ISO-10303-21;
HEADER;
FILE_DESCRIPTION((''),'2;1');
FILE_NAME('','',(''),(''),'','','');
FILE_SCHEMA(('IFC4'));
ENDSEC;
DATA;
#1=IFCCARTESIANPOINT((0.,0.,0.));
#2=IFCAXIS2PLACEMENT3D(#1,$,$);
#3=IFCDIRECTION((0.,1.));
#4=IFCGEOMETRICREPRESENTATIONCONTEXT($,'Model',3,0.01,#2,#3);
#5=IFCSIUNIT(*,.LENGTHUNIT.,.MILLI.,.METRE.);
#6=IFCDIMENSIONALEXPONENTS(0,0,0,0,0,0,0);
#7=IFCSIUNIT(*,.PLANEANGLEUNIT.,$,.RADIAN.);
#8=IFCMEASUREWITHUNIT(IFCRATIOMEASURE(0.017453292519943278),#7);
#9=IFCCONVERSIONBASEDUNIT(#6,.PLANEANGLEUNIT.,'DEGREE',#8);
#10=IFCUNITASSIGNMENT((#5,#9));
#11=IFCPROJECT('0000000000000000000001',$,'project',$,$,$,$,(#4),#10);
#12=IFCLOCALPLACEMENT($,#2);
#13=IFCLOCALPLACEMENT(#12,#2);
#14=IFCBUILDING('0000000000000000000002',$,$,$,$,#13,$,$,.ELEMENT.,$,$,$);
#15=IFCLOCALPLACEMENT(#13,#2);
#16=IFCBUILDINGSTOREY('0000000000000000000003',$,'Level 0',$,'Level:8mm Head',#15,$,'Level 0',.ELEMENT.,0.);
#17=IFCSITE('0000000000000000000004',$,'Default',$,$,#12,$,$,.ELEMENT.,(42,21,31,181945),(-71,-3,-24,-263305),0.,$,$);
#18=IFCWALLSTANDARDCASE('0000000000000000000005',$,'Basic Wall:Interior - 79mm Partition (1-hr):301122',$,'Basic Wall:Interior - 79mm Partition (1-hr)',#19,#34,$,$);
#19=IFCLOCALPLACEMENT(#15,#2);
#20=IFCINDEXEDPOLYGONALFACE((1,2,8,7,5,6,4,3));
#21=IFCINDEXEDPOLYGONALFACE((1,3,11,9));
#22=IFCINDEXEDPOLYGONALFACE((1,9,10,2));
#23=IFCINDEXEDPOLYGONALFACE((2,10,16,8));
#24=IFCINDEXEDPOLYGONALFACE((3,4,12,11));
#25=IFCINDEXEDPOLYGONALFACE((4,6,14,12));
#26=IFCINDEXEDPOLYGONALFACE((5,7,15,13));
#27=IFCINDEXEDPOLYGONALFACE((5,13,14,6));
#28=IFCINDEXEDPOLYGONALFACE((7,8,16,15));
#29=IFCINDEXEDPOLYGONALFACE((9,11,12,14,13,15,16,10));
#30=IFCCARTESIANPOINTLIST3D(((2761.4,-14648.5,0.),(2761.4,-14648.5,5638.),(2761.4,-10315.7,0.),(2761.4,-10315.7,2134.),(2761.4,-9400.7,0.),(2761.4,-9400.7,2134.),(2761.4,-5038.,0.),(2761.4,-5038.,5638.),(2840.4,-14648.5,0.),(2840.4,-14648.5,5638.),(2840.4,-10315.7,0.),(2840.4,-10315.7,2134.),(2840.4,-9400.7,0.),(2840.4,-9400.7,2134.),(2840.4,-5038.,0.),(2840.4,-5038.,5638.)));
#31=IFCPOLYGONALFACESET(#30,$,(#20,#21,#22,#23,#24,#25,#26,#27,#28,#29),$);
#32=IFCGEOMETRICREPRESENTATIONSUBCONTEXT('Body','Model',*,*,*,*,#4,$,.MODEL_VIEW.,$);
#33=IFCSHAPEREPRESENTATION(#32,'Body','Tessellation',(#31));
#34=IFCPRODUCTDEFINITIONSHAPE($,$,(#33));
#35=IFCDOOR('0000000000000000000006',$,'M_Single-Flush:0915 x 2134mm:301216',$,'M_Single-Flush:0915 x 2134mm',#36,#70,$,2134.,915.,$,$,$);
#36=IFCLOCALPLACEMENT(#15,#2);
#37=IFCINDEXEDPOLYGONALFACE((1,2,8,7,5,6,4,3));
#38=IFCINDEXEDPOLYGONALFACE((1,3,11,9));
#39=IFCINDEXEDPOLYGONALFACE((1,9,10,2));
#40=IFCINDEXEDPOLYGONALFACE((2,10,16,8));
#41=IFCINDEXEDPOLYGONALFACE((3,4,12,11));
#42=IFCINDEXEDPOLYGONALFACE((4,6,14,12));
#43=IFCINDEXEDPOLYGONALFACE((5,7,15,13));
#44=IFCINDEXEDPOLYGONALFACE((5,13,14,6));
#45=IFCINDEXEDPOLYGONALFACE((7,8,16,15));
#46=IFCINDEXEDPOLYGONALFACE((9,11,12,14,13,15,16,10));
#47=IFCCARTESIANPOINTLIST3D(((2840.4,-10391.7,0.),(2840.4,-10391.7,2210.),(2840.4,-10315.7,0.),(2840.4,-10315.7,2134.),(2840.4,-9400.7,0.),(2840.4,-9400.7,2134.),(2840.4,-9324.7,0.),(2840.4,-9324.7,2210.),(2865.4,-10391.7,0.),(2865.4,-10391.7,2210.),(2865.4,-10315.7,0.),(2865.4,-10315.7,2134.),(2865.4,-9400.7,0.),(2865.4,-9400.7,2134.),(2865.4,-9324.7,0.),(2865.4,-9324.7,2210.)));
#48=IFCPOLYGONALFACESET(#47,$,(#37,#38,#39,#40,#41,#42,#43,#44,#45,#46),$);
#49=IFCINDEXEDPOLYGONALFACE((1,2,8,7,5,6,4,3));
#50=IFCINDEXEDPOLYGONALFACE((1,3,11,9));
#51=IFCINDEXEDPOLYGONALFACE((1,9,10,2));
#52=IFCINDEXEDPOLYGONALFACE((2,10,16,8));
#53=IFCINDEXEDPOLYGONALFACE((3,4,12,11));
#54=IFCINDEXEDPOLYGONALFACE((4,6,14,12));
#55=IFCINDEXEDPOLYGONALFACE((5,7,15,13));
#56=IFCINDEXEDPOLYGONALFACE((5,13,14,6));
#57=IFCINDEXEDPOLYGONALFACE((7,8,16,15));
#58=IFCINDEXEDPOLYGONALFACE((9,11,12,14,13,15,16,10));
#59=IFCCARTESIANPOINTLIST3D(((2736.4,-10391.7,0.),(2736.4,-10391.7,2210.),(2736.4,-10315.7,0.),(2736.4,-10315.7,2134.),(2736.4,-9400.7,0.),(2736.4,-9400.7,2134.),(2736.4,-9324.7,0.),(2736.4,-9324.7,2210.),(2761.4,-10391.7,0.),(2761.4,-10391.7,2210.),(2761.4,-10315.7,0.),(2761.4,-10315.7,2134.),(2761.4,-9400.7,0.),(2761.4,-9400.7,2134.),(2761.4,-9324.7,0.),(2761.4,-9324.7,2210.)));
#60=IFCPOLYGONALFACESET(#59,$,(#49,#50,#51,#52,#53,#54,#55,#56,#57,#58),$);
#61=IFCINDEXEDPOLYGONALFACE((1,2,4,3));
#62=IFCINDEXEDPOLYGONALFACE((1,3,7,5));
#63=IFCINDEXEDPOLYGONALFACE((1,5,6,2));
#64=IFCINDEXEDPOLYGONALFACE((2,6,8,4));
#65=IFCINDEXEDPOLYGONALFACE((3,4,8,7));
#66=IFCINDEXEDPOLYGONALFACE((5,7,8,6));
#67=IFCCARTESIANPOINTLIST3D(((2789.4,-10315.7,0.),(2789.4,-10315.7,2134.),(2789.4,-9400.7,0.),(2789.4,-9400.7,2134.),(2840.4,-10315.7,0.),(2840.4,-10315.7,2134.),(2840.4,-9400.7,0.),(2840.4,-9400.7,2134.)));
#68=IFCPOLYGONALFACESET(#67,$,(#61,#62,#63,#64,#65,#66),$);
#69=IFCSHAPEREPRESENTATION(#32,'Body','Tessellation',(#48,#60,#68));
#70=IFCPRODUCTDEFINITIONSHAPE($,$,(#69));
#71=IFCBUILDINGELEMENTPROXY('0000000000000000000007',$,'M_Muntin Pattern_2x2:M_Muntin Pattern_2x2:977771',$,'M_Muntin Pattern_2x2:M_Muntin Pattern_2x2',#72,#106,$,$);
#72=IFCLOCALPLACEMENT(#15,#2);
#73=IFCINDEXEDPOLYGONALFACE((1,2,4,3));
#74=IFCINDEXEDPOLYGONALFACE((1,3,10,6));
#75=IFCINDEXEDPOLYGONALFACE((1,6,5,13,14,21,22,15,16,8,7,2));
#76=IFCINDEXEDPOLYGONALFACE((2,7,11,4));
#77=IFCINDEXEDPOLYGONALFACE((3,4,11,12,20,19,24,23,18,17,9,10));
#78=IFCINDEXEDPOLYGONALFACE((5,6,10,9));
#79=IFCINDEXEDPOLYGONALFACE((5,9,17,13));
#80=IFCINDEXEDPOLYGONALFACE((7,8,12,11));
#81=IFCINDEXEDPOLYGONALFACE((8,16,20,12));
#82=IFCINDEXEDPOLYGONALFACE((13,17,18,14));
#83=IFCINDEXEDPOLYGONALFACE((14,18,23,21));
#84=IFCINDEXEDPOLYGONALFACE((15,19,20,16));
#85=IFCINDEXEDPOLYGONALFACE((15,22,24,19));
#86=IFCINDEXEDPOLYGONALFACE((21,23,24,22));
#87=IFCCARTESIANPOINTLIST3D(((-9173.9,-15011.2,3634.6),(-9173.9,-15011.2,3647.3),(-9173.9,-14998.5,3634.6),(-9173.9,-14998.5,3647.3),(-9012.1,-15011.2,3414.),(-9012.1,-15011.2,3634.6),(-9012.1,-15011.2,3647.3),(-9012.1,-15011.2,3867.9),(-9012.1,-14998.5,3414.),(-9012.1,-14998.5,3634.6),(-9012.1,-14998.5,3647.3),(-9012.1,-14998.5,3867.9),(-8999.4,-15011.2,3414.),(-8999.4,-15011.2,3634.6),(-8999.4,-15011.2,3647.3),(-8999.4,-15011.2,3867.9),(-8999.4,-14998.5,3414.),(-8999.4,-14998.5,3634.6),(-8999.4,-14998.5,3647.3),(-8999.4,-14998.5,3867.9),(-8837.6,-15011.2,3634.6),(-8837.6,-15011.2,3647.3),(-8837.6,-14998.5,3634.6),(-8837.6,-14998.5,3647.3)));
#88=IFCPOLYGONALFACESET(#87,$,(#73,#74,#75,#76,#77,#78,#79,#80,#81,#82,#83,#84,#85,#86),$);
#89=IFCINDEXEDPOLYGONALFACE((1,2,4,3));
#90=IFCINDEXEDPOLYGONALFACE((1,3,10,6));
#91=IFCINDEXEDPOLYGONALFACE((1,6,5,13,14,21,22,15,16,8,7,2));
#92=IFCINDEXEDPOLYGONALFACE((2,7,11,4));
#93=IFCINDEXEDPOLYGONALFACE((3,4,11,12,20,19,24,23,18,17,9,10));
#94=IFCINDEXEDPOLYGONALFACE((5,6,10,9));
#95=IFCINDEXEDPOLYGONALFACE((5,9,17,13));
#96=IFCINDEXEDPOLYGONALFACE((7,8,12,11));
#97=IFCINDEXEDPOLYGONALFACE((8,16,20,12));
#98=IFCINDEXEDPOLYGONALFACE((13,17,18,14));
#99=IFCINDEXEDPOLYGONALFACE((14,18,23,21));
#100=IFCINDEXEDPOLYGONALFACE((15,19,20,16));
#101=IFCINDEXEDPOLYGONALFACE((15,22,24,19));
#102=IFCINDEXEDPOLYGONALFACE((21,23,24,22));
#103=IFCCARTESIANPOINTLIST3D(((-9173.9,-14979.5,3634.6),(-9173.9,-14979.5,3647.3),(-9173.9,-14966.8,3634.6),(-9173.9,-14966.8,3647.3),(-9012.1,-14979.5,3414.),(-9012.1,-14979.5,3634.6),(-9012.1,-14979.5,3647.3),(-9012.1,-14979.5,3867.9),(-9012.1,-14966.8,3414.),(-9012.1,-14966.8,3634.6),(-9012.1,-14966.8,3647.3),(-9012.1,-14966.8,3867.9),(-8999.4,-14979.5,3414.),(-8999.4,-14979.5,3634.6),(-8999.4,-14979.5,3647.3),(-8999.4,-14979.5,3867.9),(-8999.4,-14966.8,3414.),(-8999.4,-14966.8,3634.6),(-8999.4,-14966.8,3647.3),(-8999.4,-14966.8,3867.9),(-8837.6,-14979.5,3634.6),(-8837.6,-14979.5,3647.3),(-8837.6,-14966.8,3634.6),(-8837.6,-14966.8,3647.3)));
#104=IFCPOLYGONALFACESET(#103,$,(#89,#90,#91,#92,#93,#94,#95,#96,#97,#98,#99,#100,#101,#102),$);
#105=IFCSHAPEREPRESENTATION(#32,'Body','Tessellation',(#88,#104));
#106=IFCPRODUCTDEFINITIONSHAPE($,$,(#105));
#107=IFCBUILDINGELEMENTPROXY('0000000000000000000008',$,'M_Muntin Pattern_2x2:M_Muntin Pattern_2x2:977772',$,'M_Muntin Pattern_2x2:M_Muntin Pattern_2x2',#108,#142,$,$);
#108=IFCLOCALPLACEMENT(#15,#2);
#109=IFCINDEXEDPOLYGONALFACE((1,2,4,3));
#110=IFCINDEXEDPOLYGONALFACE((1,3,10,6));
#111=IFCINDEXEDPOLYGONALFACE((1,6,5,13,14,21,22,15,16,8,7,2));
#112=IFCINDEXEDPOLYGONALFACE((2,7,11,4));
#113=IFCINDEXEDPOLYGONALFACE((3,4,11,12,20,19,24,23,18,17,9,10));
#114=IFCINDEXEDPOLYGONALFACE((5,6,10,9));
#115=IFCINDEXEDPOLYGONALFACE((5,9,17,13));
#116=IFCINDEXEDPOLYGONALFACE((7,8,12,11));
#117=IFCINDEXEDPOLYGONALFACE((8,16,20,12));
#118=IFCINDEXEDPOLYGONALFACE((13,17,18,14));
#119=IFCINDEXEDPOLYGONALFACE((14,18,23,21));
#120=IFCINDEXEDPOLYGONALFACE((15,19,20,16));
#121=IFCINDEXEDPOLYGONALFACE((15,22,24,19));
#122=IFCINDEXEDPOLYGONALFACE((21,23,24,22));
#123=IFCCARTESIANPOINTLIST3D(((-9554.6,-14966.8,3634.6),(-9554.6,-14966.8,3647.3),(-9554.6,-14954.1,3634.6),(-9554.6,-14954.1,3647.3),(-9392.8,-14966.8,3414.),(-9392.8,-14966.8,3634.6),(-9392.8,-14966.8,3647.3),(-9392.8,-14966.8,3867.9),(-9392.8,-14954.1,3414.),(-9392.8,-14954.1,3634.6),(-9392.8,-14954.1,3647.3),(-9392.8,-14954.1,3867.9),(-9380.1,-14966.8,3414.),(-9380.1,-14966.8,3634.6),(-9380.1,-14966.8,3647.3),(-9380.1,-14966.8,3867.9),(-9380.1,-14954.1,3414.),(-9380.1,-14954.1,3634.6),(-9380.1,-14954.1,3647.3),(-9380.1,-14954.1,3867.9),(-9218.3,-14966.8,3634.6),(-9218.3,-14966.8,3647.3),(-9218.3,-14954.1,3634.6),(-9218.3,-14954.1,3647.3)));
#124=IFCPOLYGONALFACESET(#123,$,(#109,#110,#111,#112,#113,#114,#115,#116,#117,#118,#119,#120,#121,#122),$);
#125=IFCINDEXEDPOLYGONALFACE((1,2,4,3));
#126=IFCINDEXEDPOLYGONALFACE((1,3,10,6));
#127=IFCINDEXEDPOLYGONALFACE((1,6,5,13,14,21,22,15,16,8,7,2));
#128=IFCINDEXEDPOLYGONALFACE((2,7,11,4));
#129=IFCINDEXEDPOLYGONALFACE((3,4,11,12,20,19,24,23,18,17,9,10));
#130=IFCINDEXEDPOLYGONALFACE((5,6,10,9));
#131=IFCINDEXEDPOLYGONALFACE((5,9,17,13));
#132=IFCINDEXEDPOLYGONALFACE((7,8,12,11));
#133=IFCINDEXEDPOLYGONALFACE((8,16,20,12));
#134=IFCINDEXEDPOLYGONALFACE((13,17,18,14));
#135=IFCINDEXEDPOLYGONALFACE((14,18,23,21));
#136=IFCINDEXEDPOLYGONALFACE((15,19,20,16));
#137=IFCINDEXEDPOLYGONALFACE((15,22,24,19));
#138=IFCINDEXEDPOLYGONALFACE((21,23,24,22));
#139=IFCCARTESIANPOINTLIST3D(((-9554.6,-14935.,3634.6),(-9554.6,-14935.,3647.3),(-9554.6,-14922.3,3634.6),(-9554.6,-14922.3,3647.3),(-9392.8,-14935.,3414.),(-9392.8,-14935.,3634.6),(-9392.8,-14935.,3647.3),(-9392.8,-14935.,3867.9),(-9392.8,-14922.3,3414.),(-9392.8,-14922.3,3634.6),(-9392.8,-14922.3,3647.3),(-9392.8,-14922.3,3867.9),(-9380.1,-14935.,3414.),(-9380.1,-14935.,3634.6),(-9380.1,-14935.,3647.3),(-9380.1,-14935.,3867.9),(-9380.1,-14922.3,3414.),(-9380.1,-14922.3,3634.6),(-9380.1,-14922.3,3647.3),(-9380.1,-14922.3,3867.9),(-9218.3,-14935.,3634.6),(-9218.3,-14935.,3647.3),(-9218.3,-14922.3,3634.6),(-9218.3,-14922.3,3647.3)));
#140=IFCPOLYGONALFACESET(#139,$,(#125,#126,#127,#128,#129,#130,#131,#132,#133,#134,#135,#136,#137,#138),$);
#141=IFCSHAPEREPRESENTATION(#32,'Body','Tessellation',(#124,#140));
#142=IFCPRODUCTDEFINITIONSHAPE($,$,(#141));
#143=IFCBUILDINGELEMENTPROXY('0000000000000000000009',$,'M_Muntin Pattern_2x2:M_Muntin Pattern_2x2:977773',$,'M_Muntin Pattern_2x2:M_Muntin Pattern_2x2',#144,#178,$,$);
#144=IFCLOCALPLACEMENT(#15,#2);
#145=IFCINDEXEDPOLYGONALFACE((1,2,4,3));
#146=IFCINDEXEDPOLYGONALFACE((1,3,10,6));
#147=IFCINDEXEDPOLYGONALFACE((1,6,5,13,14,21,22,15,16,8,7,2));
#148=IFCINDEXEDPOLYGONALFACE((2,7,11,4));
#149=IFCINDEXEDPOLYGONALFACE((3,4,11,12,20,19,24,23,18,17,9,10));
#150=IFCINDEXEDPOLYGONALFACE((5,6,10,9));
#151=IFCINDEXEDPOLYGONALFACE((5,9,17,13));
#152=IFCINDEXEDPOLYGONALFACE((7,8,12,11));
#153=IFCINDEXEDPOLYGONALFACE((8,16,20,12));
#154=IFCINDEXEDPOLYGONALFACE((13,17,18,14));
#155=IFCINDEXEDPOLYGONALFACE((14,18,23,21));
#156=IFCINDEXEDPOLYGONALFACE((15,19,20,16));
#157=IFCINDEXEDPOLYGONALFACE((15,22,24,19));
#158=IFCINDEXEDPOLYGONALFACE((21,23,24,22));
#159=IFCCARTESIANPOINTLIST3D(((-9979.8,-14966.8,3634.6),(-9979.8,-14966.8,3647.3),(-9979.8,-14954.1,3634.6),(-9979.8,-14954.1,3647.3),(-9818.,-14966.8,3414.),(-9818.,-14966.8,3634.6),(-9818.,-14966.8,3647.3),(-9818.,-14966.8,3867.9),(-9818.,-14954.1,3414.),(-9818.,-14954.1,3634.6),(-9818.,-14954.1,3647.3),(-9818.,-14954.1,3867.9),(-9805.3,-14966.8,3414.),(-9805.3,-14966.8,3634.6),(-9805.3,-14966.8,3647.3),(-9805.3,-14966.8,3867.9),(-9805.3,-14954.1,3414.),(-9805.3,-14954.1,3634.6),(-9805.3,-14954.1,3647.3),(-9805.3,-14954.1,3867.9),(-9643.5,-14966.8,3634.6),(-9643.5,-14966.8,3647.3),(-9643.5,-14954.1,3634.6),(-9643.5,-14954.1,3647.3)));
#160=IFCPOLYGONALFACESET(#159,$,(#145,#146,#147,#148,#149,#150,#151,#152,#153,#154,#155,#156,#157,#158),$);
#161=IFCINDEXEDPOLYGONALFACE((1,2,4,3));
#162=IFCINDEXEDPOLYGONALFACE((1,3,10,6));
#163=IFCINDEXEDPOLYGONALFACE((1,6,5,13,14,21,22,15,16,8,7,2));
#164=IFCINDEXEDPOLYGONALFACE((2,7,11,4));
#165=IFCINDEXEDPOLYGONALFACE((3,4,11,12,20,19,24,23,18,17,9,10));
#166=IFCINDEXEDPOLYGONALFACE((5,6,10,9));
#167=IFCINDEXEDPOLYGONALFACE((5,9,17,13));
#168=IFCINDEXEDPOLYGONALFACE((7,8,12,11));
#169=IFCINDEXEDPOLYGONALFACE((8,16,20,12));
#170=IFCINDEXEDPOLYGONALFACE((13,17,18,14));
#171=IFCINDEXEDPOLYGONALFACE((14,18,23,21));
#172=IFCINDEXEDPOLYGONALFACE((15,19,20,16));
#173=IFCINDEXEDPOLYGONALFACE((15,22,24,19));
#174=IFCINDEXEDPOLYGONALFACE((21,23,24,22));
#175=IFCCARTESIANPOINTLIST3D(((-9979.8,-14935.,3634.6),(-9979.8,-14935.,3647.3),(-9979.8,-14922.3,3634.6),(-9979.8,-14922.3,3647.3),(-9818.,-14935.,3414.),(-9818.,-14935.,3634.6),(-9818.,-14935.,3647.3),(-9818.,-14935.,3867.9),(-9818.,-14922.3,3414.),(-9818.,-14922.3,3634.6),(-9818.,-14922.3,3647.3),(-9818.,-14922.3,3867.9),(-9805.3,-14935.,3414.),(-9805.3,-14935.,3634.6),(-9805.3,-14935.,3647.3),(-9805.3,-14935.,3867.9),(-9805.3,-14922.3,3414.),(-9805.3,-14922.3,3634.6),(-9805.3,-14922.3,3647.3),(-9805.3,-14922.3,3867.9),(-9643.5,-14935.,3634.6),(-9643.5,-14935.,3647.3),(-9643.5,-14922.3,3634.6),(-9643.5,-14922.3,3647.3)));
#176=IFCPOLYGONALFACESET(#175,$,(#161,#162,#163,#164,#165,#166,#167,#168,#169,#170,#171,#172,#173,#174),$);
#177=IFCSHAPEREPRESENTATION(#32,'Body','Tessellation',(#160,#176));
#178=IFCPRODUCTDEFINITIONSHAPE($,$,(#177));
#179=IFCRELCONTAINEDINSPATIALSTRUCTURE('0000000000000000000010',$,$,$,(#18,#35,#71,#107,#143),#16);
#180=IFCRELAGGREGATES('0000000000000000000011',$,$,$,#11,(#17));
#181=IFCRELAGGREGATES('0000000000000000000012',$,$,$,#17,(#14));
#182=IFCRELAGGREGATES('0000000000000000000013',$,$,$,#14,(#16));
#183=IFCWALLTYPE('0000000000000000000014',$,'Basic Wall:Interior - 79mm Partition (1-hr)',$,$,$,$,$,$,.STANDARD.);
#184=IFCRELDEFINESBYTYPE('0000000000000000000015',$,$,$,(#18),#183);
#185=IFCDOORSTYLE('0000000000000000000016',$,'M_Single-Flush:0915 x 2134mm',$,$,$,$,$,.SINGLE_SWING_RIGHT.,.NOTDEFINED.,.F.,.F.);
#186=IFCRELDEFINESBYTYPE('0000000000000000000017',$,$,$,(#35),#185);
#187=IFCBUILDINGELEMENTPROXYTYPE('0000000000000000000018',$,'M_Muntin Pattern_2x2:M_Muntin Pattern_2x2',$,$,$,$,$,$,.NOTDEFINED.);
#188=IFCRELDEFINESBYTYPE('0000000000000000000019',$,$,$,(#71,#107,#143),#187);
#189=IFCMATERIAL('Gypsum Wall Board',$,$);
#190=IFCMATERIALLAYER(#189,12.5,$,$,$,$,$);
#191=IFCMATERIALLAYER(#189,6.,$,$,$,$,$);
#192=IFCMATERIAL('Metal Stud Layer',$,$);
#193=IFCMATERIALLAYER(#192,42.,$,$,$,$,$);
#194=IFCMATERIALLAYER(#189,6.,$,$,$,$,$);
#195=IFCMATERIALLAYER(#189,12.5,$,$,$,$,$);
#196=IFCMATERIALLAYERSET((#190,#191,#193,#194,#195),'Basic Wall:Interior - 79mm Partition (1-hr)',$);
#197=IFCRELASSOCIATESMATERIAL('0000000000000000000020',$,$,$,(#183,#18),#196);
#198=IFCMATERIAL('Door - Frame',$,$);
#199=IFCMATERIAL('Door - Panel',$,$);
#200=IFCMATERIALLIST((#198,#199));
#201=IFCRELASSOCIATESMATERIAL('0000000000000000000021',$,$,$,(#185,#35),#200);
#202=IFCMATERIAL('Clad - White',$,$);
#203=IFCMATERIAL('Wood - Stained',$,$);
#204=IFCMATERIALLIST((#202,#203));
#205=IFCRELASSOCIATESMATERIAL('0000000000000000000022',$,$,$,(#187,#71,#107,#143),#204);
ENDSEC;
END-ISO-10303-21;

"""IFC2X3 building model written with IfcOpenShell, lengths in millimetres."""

from ifc_helpers import new_model, entity, si_unit, converted_unit, direction, frame, frame_2d, origin, origin_2d_with_axis, place, context, subcontext, project, spatial, polyline, rectangle, outline, extrude, clip, bounded_halfspace, source, transform, mapped, material, material_list, layer, layer_set, layer_usage, type_object, type_shapes, element, fill, save


model = new_model("IFC2X3")

# Units and contexts
model_context = context("Model", 3, precision=0.01, world=origin(), true_north=direction((0.0, 1.0)))
body_context = subcontext(model_context, "Body", "Model", "MODEL_VIEW")
ifc_project = project(units=[si_unit("LENGTHUNIT", "METRE", prefix="MILLI"), converted_unit("PLANEANGLEUNIT", "DEGREE", entity("IfcRatioMeasure", 0.017453292519943278), si_unit("PLANEANGLEUNIT", "RADIAN"), dimensions=[0, 0, 0, 0, 0, 0, 0])], contexts=[model_context])

# Site, building, storey
site_placement = place(None, origin())
site = spatial("IfcSite", under=ifc_project, at=site_placement, Name="Default", CompositionType="ELEMENT", RefLatitude=(42, 21, 31, 181945), RefLongitude=(-71, -3, -24, -263305), RefElevation=0.0)
building_placement = place(site_placement, origin())
building = spatial("IfcBuilding", under=site, at=building_placement, CompositionType="ELEMENT")
storey_placement = place(building_placement, origin())
storey = spatial("IfcBuildingStorey", under=building, at=storey_placement, Name="Level 0", ObjectType="Level:8mm Head", LongName="Level 0", CompositionType="ELEMENT", Elevation=0.0)

# Shared definitions
ifc_material_1 = material(Name="Metal Stud Layer")
ifc_material_2 = material(Name="Gypsum Wall Board")
ifc_material_3 = material(Name="Door - Frame")
ifc_material_4 = material(Name="Door - Panel")
ifc_material_list_1 = material_list([ifc_material_3, ifc_material_4])

# Wall, opening, door
ifc_layer_1 = layer(ifc_material_2, 12.5)
ifc_layer_2 = layer(ifc_material_2, 6.0)
ifc_layer_3 = layer(ifc_material_1, 42.0)
ifc_layer_4 = layer(ifc_material_2, 6.0)
ifc_layer_5 = layer(ifc_material_2, 12.5)
ifc_layer_set_1 = layer_set([ifc_layer_1, ifc_layer_2, ifc_layer_3, ifc_layer_4, ifc_layer_5], Name="Basic Wall:Interior - 79mm Partition (1-hr)")
ifc_layer_usage_1 = layer_usage(ifc_layer_set_1, "AXIS2", "NEGATIVE", 39.5)
wall_type_1 = type_object("IfcWallType", Name="Basic Wall:Interior - 79mm Partition (1-hr)", PredefinedType="STANDARD", material=ifc_layer_set_1)
door_style_1 = type_object("IfcDoorStyle", Name="M_Single-Flush:0915 x 2134mm", ConstructionType="NOTDEFINED", OperationType="SINGLE_SWING_RIGHT", ParameterTakesPrecedence=False, Sizeable=False, material=ifc_material_list_1)
shared_shape_1 = source(origin(), body_context, "Body", "SweptSolid", [
    extrude(outline(polyline([(-533.5, -1124.0), (533.5, -1124.0), (533.5, 1086.0), (457.5, 1086.0), (457.5, -1048.0), (-457.5, -1048.0), (-457.5, 1086.0), (-533.5, 1086.0), (-533.5, -1124.0)])), frame((457.5, 79.0, 1086.0), z_axis=(0.0, 1.0, 0.0), x_axis=(1.0, 0.0, 0.0)), (0.0, 0.0, 1.0), 25.0),
    extrude(outline(polyline([(-1124.0, -533.5), (1086.0, -533.5), (1086.0, -457.5), (-1048.0, -457.5), (-1048.0, 457.5), (1086.0, 457.5), (1086.0, 533.5), (-1124.0, 533.5), (-1124.0, -533.5)])), frame((457.5, -25.0, 1086.0), z_axis=(0.0, 1.0, 0.0), x_axis=(0.0, 0.0, -1.0)), (0.0, 0.0, 1.0), 25.0),
    extrude(rectangle(XDim=51.0, YDim=915.0, at=origin_2d_with_axis()), frame((457.5, 53.5, 0.0), z_axis=(0.0, 0.0, 1.0), x_axis=(0.0, 1.0, 0.0)), (0.0, 0.0, 1.0), 2134.0),
])
type_shapes(door_style_1, [shared_shape_1])
wall_1_placement = place(storey_placement, frame((2800.9, -5038.0, 0.0), z_axis=(0.0, 0.0, 1.0), x_axis=(0.0, -1.0, 0.0)))
wall_1 = element("IfcWallStandardCase", 1, at=wall_1_placement, inside=storey, type_object=wall_type_1, material=ifc_layer_usage_1, Name="Basic Wall:Interior - 79mm Partition (1-hr):301122", ObjectType="Basic Wall:Interior - 79mm Partition (1-hr)", context=body_context, shape_type="Clipping", body=[
    clip(extrude(rectangle(XDim=9610.5, YDim=79.0, at=frame_2d((4805.3, 0.0), x_axis=(-1.0, 0.0))), origin(), (0.0, 0.0, 1.0), 5638.0), bounded_halfspace(frame((0.0, -39.5, 5638.0), z_axis=(0.0, 0.0, -1.0), x_axis=(1.0, 0.0, 0.0)), True, frame((0.0, -39.5, 5638.0)), polyline([(0.0, 0.0), (2929280.4, 0.0), (2929280.4, 24079.2), (0.0, 24079.2), (0.0, 0.0)]))),
])
opening_1_placement = place(wall_1_placement, frame((4362.6, -39.5, 0.0)))
opening_1 = element("IfcOpeningElement", 2, at=opening_1_placement, cuts=wall_1, ObjectType="Opening", context=body_context, shape_type="SweptSolid", body=[
    extrude(rectangle(XDim=915.0, YDim=2134.0, at=frame_2d((1067.0, 457.5), x_axis=(0.0, 1.0))), frame((0.0, 0.0, 0.0), z_axis=(0.0, 1.0, 0.0), x_axis=(0.0, 0.0, 1.0)), (0.0, 0.0, 1.0), 79.0),
])
door_1_placement = place(opening_1_placement, origin())
door_1 = element("IfcDoor", 3, at=door_1_placement, inside=storey, type_object=door_style_1, material=ifc_material_list_1, Name="M_Single-Flush:0915 x 2134mm:301216", ObjectType="M_Single-Flush:0915 x 2134mm", OverallHeight=2134.0, OverallWidth=915.0, context=body_context, shape_type="MappedRepresentation", body=[
    mapped(shared_shape_1, transform((0.0, 0.0, 0.0), scale=1.0)),
])
fill(opening_1, door_1)

# Building element proxies
ifc_material_5 = material(Name="Clad - White")
ifc_material_6 = material(Name="Wood - Stained")
ifc_material_list_2 = material_list([ifc_material_5, ifc_material_6])
building_element_proxy_type_1 = type_object("IfcBuildingElementProxyType", Name="M_Muntin Pattern_2x2:M_Muntin Pattern_2x2", PredefinedType="NOTDEFINED", material=ifc_material_list_2)
shared_shape_2 = source(origin(), body_context, "Body", "SweptSolid", [
    extrude(outline(polyline([(6.4, -6.4), (227.0, -6.4), (227.0, 6.3), (6.4, 6.3), (6.4, 168.2), (-6.3, 168.2), (-6.3, 6.3), (-227.0, 6.3), (-227.0, -6.4), (-6.3, -6.4), (-6.3, -168.1), (6.4, -168.1), (6.4, -6.4)])), frame((0.0, 9.5, 227.0), z_axis=(0.0, 1.0, 0.0), x_axis=(0.0, 0.0, 1.0)), (0.0, 0.0, 1.0), 12.7),
    extrude(outline(polyline([(6.4, -6.4), (227.0, -6.4), (227.0, 6.3), (6.4, 6.3), (6.4, 168.2), (-6.3, 168.2), (-6.3, 6.3), (-227.0, 6.3), (-227.0, -6.4), (-6.3, -6.4), (-6.3, -168.1), (6.4, -168.1), (6.4, -6.4)])), frame((0.0, -22.2, 227.0), z_axis=(0.0, 1.0, 0.0), x_axis=(0.0, 0.0, 1.0)), (0.0, 0.0, 1.0), 12.7),
])
type_shapes(building_element_proxy_type_1, [shared_shape_2])
for number, where, z_axis, x_axis, name in (
    (4, (-9005.7, -14989.0, 3414.0), (0.0, 0.0, 1.0), (-1.0, 0.0, 0.0), "M_Muntin Pattern_2x2:M_Muntin Pattern_2x2:977771"),
    (5, (-9386.5, -14944.6, 3414.0), (0.0, 0.0, 1.0), (-1.0, 0.0, 0.0), "M_Muntin Pattern_2x2:M_Muntin Pattern_2x2:977772"),
    (6, (-9811.7, -14944.6, 3414.0), (0.0, 0.0, 1.0), (-1.0, 0.0, 0.0), "M_Muntin Pattern_2x2:M_Muntin Pattern_2x2:977773"),
):
    element("IfcBuildingElementProxy", number, at=place(storey_placement, frame(where, z_axis=z_axis, x_axis=x_axis)), inside=storey, type_object=building_element_proxy_type_1, material=ifc_material_list_2, Name=name, ObjectType="M_Muntin Pattern_2x2:M_Muntin Pattern_2x2", context=body_context, shape_type="MappedRepresentation", body=[
        mapped(shared_shape_2, transform((0.0, 0.0, 0.0), scale=1.0)),
    ])

save(model, "model.ifc")
